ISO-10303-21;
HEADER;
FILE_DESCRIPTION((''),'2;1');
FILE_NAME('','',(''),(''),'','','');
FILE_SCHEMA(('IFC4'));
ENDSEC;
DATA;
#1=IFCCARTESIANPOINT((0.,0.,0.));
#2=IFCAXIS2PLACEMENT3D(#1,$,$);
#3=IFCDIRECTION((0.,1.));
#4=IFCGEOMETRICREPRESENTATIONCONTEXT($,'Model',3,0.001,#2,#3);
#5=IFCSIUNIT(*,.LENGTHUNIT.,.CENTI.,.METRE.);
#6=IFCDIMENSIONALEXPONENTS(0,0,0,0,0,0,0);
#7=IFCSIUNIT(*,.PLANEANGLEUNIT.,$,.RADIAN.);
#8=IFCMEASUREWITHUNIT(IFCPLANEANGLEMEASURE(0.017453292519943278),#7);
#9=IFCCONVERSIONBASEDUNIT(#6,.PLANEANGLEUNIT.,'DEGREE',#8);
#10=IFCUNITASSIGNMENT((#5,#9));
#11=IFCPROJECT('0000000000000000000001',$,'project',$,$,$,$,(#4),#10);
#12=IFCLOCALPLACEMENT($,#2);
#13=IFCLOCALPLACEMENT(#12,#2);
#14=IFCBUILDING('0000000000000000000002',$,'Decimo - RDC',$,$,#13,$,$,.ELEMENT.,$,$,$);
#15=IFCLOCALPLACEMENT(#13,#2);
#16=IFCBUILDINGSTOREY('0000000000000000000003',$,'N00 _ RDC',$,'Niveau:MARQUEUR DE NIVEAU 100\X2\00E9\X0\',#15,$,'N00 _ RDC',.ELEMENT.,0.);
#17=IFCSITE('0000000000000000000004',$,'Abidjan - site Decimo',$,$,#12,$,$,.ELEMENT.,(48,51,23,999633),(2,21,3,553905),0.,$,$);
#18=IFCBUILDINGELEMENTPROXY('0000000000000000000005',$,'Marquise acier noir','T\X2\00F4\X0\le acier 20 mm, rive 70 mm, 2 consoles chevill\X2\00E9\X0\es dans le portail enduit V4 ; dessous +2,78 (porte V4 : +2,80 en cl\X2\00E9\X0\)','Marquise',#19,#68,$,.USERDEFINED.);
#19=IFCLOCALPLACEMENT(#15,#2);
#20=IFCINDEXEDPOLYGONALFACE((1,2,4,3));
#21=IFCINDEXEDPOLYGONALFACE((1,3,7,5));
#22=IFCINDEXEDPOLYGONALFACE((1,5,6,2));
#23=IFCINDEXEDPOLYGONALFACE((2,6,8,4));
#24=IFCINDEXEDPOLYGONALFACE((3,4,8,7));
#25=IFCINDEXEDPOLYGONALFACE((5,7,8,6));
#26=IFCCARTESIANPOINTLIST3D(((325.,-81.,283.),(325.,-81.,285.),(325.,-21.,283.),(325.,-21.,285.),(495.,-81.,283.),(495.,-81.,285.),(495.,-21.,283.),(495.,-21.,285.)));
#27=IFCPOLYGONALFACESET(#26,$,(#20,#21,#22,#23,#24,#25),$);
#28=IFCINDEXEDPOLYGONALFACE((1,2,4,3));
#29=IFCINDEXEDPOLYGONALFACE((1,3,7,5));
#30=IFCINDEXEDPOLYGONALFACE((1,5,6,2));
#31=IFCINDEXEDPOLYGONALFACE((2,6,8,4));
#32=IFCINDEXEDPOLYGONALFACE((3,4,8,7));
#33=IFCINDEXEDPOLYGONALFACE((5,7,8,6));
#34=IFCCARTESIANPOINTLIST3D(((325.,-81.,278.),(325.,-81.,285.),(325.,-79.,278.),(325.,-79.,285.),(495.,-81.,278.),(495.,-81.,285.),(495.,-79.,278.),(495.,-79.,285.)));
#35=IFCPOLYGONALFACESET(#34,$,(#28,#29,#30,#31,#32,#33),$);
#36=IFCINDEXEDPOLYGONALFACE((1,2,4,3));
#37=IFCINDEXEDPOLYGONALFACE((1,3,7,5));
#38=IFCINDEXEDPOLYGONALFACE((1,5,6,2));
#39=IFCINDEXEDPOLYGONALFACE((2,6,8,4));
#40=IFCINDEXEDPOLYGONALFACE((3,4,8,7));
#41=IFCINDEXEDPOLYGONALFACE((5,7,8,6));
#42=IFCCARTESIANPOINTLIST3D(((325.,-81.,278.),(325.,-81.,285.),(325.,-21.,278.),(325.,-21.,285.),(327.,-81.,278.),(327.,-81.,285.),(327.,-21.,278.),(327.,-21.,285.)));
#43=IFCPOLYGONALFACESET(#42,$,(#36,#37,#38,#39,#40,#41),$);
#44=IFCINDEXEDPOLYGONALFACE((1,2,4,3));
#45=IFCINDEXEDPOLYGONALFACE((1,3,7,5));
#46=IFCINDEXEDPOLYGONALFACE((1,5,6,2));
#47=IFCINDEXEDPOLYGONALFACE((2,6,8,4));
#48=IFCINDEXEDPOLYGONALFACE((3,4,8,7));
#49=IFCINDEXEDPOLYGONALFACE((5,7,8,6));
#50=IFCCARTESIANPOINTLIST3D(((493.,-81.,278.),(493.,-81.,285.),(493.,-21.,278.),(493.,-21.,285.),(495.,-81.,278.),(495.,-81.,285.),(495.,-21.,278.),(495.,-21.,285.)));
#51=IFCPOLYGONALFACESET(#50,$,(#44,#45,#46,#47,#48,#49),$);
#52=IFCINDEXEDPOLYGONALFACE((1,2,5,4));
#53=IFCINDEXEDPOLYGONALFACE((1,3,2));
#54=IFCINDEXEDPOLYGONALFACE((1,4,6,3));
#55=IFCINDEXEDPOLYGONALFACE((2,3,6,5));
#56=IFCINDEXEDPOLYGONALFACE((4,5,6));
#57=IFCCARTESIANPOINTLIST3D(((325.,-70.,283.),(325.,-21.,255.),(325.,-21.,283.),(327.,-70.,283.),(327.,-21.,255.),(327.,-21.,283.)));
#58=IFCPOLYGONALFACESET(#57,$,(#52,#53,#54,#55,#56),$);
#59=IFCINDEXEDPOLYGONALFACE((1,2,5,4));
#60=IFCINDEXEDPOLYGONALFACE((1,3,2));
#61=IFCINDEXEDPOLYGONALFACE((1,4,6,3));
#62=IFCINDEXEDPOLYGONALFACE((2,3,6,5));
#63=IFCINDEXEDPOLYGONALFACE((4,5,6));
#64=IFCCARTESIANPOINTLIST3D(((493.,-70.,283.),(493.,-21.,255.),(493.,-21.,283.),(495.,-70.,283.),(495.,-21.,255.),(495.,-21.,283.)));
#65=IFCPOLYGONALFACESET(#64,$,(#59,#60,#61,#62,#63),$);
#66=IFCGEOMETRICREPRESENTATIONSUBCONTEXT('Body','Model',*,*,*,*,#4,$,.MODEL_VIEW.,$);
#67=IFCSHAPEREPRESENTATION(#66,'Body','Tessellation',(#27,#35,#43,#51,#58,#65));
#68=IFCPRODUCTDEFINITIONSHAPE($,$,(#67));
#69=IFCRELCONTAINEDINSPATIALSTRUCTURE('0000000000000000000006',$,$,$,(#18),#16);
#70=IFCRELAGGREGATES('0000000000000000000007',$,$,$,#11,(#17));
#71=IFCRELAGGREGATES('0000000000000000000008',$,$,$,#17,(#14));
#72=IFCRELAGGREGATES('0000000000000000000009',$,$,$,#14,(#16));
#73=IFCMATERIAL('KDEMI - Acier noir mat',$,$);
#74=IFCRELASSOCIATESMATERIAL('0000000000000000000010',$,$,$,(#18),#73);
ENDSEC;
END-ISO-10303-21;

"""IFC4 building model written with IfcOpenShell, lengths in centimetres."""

from ifc_helpers import new_model, entity, si_unit, converted_unit, direction, frame, frame_2d, origin, origin_with_axes, place, context, subcontext, project, spatial, polyline, rectangle, outline, extrude, material, element, save


model = new_model("IFC4")

# Units and contexts
model_context = context("Model", 3, precision=0.001, world=origin(), true_north=direction((0.0, 1.0)))
body_context = subcontext(model_context, "Body", "Model", "MODEL_VIEW")
ifc_project = project(units=[si_unit("LENGTHUNIT", "METRE", prefix="CENTI"), converted_unit("PLANEANGLEUNIT", "DEGREE", entity("IfcPlaneAngleMeasure", 0.017453292519943278), si_unit("PLANEANGLEUNIT", "RADIAN"), dimensions=[0, 0, 0, 0, 0, 0, 0])], contexts=[model_context])

# Site, building, storey
site_placement = place(None, origin())
site = spatial("IfcSite", under=ifc_project, at=site_placement, Name="Abidjan - site Decimo", CompositionType="ELEMENT", RefLatitude=(48, 51, 23, 999633), RefLongitude=(2, 21, 3, 553905), RefElevation=0.0)
building_placement = place(site_placement, origin())
building = spatial("IfcBuilding", under=site, at=building_placement, Name="Decimo - RDC", CompositionType="ELEMENT")
storey_placement = place(building_placement, origin())
storey = spatial("IfcBuildingStorey", under=building, at=storey_placement, Name="N00 _ RDC", ObjectType="Niveau:MARQUEUR DE NIVEAU 100é", LongName="N00 _ RDC", CompositionType="ELEMENT", Elevation=0.0)

# Shared definitions
ifc_material_1 = material(Name="KDEMI - Acier noir mat")

# Building element proxy
proxy_1_placement = place(storey_placement, origin_with_axes())
element("IfcBuildingElementProxy", 1, at=proxy_1_placement, inside=storey, material=ifc_material_1, Name="Marquise acier noir", Description="Tôle acier 20 mm, rive 70 mm, 2 consoles chevillées dans le portail enduit V4 ; dessous +2,78 (porte V4 : +2,80 en clé)", ObjectType="Marquise", PredefinedType="USERDEFINED", context=body_context, shape_type="SweptSolid", body=[
    extrude(rectangle(XDim=170.0, YDim=60.0, at=frame_2d((410.0, -51.0))), frame((0.0, 0.0, 283.0)), (0.0, 0.0, 1.0), 2.0),
    extrude(rectangle(XDim=170.0, YDim=2.0, at=frame_2d((410.0, -80.0))), frame((0.0, 0.0, 278.0)), (0.0, 0.0, 1.0), 7.0),
    extrude(rectangle(XDim=2.0, YDim=60.0, at=frame_2d((326.0, -51.0))), frame((0.0, 0.0, 278.0)), (0.0, 0.0, 1.0), 7.0),
    extrude(rectangle(XDim=2.0, YDim=60.0, at=frame_2d((494.0, -51.0))), frame((0.0, 0.0, 278.0)), (0.0, 0.0, 1.0), 7.0),
    extrude(outline(polyline([(-21.0, 255.0), (-70.0, 283.0), (-21.0, 283.0), (-21.0, 255.0)])), frame((325.0, 0.0, 0.0), z_axis=(1.0, 0.0, 0.0), x_axis=(0.0, 1.0, 0.0)), (0.0, 0.0, 1.0), 2.0),
    extrude(outline(polyline([(-21.0, 255.0), (-70.0, 283.0), (-21.0, 283.0), (-21.0, 255.0)])), frame((493.0, 0.0, 0.0), z_axis=(1.0, 0.0, 0.0), x_axis=(0.0, 1.0, 0.0)), (0.0, 0.0, 1.0), 2.0),
])

save(model, "model.ifc")
